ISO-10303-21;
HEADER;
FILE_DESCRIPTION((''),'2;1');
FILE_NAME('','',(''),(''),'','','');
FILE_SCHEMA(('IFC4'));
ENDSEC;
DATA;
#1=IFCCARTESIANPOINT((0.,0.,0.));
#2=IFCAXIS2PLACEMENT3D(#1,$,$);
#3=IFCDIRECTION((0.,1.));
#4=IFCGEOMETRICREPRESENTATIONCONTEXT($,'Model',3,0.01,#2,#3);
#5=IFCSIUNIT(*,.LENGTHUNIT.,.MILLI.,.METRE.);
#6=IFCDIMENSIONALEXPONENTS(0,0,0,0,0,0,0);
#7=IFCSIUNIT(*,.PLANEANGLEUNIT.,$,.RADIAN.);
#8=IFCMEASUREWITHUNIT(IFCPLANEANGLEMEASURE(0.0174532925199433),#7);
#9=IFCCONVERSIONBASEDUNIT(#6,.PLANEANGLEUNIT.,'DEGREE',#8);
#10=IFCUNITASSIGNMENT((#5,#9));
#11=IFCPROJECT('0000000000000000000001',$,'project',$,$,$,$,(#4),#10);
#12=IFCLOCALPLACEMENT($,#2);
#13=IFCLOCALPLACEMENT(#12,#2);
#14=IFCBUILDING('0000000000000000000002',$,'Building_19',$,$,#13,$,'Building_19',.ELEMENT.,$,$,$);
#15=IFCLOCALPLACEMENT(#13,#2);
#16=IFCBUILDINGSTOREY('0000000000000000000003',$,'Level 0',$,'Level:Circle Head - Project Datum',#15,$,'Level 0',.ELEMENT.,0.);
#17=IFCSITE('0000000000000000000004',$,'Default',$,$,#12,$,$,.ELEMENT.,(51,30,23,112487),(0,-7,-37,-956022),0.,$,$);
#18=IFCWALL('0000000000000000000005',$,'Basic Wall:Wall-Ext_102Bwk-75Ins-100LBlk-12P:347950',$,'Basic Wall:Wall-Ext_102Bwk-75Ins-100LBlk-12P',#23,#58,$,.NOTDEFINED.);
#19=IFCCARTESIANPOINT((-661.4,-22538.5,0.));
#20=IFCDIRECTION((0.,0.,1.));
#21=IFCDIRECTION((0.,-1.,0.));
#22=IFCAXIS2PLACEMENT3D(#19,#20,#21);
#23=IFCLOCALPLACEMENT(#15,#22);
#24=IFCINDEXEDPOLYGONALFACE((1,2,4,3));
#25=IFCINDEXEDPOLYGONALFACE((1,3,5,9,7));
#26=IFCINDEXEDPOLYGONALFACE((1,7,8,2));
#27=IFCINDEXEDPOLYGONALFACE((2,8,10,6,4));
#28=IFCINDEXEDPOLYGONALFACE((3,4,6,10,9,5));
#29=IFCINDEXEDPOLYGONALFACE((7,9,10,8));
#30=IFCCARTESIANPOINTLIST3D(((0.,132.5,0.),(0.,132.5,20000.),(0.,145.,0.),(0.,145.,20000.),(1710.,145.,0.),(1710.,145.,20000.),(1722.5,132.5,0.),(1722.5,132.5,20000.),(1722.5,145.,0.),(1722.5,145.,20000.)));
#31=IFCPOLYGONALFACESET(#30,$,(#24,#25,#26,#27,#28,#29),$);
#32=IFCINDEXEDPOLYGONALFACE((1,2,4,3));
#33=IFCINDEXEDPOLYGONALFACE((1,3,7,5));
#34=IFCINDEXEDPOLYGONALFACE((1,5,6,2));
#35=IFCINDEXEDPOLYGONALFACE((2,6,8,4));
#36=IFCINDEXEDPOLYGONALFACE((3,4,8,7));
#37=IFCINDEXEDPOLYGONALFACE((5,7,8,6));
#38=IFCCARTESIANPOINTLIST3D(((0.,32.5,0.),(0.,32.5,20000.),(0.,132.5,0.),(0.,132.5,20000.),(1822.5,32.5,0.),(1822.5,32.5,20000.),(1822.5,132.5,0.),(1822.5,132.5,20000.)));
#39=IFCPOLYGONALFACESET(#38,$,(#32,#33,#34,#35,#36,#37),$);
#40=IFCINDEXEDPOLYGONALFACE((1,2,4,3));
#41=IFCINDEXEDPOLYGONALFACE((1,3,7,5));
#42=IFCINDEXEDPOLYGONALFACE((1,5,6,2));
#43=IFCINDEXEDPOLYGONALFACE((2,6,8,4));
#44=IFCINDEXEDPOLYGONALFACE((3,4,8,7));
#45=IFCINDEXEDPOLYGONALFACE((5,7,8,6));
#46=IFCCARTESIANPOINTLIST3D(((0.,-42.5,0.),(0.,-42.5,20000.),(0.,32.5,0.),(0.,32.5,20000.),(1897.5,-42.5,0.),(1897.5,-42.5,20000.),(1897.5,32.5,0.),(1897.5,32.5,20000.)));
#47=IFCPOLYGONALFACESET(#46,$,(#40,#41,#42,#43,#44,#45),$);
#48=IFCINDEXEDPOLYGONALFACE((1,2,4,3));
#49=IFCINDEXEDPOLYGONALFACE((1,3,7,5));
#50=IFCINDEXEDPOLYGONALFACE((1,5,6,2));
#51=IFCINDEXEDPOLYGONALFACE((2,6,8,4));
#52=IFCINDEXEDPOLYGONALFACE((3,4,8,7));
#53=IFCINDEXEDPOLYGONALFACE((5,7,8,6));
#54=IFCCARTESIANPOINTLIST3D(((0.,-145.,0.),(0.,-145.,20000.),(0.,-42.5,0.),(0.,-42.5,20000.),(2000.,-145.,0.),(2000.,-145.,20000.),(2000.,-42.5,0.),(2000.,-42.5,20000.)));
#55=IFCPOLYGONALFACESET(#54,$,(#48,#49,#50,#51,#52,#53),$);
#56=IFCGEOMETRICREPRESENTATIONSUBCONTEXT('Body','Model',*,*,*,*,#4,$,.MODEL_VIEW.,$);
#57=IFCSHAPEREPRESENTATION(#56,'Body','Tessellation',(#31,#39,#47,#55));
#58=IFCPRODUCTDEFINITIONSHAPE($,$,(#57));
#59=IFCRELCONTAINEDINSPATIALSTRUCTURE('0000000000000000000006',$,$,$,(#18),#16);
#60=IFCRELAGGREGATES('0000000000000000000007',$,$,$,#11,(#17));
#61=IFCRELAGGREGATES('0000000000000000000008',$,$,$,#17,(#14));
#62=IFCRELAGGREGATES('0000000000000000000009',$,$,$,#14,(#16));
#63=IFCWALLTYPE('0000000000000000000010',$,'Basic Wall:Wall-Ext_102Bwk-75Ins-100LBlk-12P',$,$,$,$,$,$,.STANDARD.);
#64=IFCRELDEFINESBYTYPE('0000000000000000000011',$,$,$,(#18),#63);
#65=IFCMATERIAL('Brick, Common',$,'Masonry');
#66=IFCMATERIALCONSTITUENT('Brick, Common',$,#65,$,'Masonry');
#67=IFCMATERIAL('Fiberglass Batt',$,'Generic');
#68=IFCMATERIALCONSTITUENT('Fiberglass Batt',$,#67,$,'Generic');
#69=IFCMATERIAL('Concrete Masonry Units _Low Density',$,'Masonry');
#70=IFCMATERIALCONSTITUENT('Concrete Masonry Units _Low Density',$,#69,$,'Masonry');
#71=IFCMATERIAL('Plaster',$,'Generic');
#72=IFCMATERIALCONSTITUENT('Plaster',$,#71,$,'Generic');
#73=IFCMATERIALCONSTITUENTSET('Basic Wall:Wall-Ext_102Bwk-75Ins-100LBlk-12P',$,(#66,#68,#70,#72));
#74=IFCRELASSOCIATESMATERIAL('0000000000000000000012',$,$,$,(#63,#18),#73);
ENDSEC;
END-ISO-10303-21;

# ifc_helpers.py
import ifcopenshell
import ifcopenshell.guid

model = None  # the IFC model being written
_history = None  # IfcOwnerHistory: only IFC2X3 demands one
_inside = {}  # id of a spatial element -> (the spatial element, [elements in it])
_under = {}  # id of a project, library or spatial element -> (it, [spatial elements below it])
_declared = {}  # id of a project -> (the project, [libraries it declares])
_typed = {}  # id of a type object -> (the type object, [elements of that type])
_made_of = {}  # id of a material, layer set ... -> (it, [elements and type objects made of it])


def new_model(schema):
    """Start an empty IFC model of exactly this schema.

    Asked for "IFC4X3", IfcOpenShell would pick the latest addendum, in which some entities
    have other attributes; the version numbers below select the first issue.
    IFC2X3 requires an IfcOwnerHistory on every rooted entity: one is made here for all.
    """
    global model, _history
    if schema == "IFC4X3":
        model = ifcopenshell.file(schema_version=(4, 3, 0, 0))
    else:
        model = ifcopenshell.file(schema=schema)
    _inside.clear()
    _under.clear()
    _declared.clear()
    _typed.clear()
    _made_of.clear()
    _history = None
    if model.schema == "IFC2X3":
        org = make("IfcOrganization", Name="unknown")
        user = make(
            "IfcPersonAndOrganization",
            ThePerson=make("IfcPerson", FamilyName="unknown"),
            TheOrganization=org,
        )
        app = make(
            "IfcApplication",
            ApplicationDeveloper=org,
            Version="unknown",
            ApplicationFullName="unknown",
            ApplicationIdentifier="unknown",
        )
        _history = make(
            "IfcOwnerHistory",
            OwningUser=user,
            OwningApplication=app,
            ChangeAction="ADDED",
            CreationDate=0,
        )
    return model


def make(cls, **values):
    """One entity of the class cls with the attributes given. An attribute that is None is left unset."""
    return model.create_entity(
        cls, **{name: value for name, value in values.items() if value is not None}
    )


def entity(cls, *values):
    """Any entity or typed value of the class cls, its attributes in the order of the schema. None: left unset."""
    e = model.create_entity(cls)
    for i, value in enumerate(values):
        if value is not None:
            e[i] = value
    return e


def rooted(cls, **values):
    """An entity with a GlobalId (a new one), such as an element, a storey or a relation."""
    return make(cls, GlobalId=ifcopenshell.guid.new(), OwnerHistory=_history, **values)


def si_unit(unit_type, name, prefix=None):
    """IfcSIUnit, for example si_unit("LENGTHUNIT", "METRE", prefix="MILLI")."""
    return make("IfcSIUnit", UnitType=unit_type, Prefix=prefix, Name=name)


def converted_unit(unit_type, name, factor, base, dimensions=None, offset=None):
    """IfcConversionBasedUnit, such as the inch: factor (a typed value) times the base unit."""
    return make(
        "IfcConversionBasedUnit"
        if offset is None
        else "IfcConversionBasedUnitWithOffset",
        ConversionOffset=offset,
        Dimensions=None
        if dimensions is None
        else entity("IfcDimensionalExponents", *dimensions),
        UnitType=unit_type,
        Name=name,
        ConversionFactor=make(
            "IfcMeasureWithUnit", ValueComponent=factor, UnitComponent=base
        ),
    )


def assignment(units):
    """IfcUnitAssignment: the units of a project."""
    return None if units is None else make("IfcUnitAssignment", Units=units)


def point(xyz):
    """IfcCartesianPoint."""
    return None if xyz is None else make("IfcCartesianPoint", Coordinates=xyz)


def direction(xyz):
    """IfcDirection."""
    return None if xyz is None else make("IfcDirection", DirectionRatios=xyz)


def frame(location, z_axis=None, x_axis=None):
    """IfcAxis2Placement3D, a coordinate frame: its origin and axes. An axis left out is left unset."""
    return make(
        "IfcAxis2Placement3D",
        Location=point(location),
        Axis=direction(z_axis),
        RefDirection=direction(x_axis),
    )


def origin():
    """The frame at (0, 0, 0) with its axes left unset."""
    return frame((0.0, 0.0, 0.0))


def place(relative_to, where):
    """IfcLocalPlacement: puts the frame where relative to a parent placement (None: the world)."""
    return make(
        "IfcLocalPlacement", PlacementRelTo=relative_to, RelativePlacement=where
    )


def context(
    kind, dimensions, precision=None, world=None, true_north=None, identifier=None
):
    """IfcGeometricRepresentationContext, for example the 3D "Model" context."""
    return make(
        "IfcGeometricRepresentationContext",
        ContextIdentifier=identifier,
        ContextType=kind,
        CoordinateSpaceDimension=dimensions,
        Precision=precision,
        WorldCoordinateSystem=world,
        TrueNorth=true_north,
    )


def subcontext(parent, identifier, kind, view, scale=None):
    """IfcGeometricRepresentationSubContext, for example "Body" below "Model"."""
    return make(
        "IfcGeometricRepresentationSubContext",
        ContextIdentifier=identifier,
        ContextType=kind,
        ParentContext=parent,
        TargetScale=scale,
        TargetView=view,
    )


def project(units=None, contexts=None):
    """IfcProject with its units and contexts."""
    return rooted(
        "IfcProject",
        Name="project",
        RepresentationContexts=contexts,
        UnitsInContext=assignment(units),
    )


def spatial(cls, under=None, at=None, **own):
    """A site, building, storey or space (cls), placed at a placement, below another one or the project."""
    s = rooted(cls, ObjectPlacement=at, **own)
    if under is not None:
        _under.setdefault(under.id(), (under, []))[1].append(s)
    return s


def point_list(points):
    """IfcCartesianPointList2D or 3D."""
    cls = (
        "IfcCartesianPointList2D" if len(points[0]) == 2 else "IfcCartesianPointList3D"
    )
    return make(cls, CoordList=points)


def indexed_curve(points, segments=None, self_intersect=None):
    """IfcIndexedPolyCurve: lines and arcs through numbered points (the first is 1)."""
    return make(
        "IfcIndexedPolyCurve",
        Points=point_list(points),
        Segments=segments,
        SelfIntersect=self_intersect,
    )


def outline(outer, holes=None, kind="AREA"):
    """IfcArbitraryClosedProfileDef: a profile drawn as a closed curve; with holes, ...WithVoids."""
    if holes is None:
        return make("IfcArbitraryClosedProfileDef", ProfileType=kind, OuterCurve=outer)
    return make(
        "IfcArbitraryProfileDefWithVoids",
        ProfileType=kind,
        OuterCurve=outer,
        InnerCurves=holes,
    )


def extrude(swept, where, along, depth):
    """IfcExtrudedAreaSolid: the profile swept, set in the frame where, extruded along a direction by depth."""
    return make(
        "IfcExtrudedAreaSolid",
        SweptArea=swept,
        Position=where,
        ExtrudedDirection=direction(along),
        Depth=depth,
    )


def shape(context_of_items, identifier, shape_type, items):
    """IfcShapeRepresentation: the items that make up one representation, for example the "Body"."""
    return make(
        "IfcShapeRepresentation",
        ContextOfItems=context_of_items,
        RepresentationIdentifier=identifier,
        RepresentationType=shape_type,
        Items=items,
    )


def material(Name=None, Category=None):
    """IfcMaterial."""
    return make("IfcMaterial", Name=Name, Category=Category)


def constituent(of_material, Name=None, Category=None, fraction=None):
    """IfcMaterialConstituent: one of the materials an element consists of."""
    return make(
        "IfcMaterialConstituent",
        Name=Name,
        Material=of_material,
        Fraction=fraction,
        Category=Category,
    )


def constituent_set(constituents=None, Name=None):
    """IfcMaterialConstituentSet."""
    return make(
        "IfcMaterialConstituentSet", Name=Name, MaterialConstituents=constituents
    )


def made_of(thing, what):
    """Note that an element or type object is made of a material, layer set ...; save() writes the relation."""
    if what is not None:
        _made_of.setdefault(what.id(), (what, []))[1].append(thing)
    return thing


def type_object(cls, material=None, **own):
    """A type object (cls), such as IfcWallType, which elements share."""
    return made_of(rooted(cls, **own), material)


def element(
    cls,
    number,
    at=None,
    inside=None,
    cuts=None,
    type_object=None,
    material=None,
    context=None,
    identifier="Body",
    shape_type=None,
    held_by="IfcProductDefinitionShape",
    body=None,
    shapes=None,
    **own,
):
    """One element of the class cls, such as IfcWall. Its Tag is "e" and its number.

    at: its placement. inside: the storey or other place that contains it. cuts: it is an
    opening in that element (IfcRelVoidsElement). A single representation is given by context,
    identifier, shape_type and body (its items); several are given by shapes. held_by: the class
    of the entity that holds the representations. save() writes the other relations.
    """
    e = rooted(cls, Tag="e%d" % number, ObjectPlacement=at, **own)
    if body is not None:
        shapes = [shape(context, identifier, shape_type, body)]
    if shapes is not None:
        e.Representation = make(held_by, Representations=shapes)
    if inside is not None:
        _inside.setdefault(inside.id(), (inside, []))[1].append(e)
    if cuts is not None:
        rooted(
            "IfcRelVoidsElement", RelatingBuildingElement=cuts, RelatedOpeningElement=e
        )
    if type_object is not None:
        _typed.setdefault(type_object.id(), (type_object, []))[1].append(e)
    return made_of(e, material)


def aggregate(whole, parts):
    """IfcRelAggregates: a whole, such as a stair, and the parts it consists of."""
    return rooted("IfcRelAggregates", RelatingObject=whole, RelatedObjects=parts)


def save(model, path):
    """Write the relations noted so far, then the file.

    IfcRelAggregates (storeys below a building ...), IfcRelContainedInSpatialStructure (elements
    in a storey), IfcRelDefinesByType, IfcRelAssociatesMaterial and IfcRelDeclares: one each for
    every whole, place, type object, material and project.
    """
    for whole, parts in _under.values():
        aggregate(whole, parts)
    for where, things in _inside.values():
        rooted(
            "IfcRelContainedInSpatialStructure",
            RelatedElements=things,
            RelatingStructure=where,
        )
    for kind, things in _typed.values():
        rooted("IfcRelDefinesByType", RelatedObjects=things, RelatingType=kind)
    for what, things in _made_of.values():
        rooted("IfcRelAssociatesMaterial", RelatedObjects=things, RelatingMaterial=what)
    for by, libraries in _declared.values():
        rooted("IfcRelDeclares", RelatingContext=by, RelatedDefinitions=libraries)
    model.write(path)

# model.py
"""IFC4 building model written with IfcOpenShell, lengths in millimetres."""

from ifc_helpers import new_model, entity, si_unit, converted_unit, direction, frame, origin, place, context, subcontext, project, spatial, indexed_curve, outline, extrude, material, constituent, constituent_set, type_object, element, save


model = new_model("IFC4")

# Units and contexts
model_context = context("Model", 3, precision=0.01, world=origin(), true_north=direction((0.0, 1.0)))
body_context = subcontext(model_context, "Body", "Model", "MODEL_VIEW")
ifc_project = project(units=[si_unit("LENGTHUNIT", "METRE", prefix="MILLI"), converted_unit("PLANEANGLEUNIT", "DEGREE", entity("IfcPlaneAngleMeasure", 0.0174532925199433), si_unit("PLANEANGLEUNIT", "RADIAN"), dimensions=[0, 0, 0, 0, 0, 0, 0])], contexts=[model_context])

# Site, building, storey
site_placement = place(None, origin())
site = spatial("IfcSite", under=ifc_project, at=site_placement, Name="Default", CompositionType="ELEMENT", RefLatitude=(51, 30, 23, 112487), RefLongitude=(0, -7, -37, -956022), RefElevation=0.0)
building_placement = place(site_placement, origin())
building = spatial("IfcBuilding", under=site, at=building_placement, Name="Building_19", LongName="Building_19", CompositionType="ELEMENT")
storey_placement = place(building_placement, origin())
storey = spatial("IfcBuildingStorey", under=building, at=storey_placement, Name="Level 0", ObjectType="Level:Circle Head - Project Datum", LongName="Level 0", CompositionType="ELEMENT", Elevation=0.0)

# Shared definitions
ifc_material_1 = material(Name="Brick, Common", Category="Masonry")
ifc_constituent_1 = constituent(ifc_material_1, Name="Brick, Common", Category="Masonry")
ifc_material_2 = material(Name="Fiberglass Batt", Category="Generic")
ifc_constituent_2 = constituent(ifc_material_2, Name="Fiberglass Batt", Category="Generic")
ifc_material_3 = material(Name="Concrete Masonry Units _Low Density", Category="Masonry")
ifc_constituent_3 = constituent(ifc_material_3, Name="Concrete Masonry Units _Low Density", Category="Masonry")
ifc_material_4 = material(Name="Plaster", Category="Generic")
ifc_constituent_4 = constituent(ifc_material_4, Name="Plaster", Category="Generic")
ifc_constituent_set_1 = constituent_set(constituents=[ifc_constituent_1, ifc_constituent_2, ifc_constituent_3, ifc_constituent_4], Name="Basic Wall:Wall-Ext_102Bwk-75Ins-100LBlk-12P")
wall_type_1 = type_object("IfcWallType", Name="Basic Wall:Wall-Ext_102Bwk-75Ins-100LBlk-12P", PredefinedType="STANDARD", material=ifc_constituent_set_1)

# Wall
wall_1_placement = place(storey_placement, frame((-661.4, -22538.5, 0.0), z_axis=(0.0, 0.0, 1.0), x_axis=(0.0, -1.0, 0.0)))
element("IfcWall", 1, at=wall_1_placement, inside=storey, type_object=wall_type_1, material=ifc_constituent_set_1, Name="Basic Wall:Wall-Ext_102Bwk-75Ins-100LBlk-12P:347950", ObjectType="Basic Wall:Wall-Ext_102Bwk-75Ins-100LBlk-12P", PredefinedType="NOTDEFINED", context=body_context, shape_type="SweptSolid", body=[
    extrude(outline(indexed_curve([(-679.0, -5.0), (1031.0, -5.0), (1031.0, 7.5), (-691.5, 7.5), (-691.5, -5.0), (-679.0, -5.0)], self_intersect=False)), frame((1031.0, 140.0, 0.0), z_axis=(0.0, 0.0, 1.0), x_axis=(-1.0, 0.0, 0.0)), (0.0, 0.0, 1.0), 20000.0),
    extrude(outline(indexed_curve([(-911.2, -50.0), (911.2, -50.0), (911.2, 50.0), (-911.2, 50.0), (-911.2, -50.0)], self_intersect=False)), frame((911.2, 82.5, 0.0)), (0.0, 0.0, 1.0), 20000.0),
    extrude(outline(indexed_curve([(-948.7, -37.5), (948.7, -37.5), (948.7, 37.5), (-948.7, 37.5), (-948.7, -37.5)], self_intersect=False)), frame((948.7, -5.0, 0.0)), (0.0, 0.0, 1.0), 20000.0),
    extrude(outline(indexed_curve([(-51.3, -1000.0), (51.2, -1000.0), (51.3, 1000.0), (-51.2, 1000.0), (-51.3, -1000.0)], self_intersect=False)), frame((1000.0, -93.8, 0.0), z_axis=(0.0, 0.0, 1.0), x_axis=(0.0, 1.0, 0.0)), (0.0, 0.0, 1.0), 20000.0),
])

save(model, "model.ifc")
